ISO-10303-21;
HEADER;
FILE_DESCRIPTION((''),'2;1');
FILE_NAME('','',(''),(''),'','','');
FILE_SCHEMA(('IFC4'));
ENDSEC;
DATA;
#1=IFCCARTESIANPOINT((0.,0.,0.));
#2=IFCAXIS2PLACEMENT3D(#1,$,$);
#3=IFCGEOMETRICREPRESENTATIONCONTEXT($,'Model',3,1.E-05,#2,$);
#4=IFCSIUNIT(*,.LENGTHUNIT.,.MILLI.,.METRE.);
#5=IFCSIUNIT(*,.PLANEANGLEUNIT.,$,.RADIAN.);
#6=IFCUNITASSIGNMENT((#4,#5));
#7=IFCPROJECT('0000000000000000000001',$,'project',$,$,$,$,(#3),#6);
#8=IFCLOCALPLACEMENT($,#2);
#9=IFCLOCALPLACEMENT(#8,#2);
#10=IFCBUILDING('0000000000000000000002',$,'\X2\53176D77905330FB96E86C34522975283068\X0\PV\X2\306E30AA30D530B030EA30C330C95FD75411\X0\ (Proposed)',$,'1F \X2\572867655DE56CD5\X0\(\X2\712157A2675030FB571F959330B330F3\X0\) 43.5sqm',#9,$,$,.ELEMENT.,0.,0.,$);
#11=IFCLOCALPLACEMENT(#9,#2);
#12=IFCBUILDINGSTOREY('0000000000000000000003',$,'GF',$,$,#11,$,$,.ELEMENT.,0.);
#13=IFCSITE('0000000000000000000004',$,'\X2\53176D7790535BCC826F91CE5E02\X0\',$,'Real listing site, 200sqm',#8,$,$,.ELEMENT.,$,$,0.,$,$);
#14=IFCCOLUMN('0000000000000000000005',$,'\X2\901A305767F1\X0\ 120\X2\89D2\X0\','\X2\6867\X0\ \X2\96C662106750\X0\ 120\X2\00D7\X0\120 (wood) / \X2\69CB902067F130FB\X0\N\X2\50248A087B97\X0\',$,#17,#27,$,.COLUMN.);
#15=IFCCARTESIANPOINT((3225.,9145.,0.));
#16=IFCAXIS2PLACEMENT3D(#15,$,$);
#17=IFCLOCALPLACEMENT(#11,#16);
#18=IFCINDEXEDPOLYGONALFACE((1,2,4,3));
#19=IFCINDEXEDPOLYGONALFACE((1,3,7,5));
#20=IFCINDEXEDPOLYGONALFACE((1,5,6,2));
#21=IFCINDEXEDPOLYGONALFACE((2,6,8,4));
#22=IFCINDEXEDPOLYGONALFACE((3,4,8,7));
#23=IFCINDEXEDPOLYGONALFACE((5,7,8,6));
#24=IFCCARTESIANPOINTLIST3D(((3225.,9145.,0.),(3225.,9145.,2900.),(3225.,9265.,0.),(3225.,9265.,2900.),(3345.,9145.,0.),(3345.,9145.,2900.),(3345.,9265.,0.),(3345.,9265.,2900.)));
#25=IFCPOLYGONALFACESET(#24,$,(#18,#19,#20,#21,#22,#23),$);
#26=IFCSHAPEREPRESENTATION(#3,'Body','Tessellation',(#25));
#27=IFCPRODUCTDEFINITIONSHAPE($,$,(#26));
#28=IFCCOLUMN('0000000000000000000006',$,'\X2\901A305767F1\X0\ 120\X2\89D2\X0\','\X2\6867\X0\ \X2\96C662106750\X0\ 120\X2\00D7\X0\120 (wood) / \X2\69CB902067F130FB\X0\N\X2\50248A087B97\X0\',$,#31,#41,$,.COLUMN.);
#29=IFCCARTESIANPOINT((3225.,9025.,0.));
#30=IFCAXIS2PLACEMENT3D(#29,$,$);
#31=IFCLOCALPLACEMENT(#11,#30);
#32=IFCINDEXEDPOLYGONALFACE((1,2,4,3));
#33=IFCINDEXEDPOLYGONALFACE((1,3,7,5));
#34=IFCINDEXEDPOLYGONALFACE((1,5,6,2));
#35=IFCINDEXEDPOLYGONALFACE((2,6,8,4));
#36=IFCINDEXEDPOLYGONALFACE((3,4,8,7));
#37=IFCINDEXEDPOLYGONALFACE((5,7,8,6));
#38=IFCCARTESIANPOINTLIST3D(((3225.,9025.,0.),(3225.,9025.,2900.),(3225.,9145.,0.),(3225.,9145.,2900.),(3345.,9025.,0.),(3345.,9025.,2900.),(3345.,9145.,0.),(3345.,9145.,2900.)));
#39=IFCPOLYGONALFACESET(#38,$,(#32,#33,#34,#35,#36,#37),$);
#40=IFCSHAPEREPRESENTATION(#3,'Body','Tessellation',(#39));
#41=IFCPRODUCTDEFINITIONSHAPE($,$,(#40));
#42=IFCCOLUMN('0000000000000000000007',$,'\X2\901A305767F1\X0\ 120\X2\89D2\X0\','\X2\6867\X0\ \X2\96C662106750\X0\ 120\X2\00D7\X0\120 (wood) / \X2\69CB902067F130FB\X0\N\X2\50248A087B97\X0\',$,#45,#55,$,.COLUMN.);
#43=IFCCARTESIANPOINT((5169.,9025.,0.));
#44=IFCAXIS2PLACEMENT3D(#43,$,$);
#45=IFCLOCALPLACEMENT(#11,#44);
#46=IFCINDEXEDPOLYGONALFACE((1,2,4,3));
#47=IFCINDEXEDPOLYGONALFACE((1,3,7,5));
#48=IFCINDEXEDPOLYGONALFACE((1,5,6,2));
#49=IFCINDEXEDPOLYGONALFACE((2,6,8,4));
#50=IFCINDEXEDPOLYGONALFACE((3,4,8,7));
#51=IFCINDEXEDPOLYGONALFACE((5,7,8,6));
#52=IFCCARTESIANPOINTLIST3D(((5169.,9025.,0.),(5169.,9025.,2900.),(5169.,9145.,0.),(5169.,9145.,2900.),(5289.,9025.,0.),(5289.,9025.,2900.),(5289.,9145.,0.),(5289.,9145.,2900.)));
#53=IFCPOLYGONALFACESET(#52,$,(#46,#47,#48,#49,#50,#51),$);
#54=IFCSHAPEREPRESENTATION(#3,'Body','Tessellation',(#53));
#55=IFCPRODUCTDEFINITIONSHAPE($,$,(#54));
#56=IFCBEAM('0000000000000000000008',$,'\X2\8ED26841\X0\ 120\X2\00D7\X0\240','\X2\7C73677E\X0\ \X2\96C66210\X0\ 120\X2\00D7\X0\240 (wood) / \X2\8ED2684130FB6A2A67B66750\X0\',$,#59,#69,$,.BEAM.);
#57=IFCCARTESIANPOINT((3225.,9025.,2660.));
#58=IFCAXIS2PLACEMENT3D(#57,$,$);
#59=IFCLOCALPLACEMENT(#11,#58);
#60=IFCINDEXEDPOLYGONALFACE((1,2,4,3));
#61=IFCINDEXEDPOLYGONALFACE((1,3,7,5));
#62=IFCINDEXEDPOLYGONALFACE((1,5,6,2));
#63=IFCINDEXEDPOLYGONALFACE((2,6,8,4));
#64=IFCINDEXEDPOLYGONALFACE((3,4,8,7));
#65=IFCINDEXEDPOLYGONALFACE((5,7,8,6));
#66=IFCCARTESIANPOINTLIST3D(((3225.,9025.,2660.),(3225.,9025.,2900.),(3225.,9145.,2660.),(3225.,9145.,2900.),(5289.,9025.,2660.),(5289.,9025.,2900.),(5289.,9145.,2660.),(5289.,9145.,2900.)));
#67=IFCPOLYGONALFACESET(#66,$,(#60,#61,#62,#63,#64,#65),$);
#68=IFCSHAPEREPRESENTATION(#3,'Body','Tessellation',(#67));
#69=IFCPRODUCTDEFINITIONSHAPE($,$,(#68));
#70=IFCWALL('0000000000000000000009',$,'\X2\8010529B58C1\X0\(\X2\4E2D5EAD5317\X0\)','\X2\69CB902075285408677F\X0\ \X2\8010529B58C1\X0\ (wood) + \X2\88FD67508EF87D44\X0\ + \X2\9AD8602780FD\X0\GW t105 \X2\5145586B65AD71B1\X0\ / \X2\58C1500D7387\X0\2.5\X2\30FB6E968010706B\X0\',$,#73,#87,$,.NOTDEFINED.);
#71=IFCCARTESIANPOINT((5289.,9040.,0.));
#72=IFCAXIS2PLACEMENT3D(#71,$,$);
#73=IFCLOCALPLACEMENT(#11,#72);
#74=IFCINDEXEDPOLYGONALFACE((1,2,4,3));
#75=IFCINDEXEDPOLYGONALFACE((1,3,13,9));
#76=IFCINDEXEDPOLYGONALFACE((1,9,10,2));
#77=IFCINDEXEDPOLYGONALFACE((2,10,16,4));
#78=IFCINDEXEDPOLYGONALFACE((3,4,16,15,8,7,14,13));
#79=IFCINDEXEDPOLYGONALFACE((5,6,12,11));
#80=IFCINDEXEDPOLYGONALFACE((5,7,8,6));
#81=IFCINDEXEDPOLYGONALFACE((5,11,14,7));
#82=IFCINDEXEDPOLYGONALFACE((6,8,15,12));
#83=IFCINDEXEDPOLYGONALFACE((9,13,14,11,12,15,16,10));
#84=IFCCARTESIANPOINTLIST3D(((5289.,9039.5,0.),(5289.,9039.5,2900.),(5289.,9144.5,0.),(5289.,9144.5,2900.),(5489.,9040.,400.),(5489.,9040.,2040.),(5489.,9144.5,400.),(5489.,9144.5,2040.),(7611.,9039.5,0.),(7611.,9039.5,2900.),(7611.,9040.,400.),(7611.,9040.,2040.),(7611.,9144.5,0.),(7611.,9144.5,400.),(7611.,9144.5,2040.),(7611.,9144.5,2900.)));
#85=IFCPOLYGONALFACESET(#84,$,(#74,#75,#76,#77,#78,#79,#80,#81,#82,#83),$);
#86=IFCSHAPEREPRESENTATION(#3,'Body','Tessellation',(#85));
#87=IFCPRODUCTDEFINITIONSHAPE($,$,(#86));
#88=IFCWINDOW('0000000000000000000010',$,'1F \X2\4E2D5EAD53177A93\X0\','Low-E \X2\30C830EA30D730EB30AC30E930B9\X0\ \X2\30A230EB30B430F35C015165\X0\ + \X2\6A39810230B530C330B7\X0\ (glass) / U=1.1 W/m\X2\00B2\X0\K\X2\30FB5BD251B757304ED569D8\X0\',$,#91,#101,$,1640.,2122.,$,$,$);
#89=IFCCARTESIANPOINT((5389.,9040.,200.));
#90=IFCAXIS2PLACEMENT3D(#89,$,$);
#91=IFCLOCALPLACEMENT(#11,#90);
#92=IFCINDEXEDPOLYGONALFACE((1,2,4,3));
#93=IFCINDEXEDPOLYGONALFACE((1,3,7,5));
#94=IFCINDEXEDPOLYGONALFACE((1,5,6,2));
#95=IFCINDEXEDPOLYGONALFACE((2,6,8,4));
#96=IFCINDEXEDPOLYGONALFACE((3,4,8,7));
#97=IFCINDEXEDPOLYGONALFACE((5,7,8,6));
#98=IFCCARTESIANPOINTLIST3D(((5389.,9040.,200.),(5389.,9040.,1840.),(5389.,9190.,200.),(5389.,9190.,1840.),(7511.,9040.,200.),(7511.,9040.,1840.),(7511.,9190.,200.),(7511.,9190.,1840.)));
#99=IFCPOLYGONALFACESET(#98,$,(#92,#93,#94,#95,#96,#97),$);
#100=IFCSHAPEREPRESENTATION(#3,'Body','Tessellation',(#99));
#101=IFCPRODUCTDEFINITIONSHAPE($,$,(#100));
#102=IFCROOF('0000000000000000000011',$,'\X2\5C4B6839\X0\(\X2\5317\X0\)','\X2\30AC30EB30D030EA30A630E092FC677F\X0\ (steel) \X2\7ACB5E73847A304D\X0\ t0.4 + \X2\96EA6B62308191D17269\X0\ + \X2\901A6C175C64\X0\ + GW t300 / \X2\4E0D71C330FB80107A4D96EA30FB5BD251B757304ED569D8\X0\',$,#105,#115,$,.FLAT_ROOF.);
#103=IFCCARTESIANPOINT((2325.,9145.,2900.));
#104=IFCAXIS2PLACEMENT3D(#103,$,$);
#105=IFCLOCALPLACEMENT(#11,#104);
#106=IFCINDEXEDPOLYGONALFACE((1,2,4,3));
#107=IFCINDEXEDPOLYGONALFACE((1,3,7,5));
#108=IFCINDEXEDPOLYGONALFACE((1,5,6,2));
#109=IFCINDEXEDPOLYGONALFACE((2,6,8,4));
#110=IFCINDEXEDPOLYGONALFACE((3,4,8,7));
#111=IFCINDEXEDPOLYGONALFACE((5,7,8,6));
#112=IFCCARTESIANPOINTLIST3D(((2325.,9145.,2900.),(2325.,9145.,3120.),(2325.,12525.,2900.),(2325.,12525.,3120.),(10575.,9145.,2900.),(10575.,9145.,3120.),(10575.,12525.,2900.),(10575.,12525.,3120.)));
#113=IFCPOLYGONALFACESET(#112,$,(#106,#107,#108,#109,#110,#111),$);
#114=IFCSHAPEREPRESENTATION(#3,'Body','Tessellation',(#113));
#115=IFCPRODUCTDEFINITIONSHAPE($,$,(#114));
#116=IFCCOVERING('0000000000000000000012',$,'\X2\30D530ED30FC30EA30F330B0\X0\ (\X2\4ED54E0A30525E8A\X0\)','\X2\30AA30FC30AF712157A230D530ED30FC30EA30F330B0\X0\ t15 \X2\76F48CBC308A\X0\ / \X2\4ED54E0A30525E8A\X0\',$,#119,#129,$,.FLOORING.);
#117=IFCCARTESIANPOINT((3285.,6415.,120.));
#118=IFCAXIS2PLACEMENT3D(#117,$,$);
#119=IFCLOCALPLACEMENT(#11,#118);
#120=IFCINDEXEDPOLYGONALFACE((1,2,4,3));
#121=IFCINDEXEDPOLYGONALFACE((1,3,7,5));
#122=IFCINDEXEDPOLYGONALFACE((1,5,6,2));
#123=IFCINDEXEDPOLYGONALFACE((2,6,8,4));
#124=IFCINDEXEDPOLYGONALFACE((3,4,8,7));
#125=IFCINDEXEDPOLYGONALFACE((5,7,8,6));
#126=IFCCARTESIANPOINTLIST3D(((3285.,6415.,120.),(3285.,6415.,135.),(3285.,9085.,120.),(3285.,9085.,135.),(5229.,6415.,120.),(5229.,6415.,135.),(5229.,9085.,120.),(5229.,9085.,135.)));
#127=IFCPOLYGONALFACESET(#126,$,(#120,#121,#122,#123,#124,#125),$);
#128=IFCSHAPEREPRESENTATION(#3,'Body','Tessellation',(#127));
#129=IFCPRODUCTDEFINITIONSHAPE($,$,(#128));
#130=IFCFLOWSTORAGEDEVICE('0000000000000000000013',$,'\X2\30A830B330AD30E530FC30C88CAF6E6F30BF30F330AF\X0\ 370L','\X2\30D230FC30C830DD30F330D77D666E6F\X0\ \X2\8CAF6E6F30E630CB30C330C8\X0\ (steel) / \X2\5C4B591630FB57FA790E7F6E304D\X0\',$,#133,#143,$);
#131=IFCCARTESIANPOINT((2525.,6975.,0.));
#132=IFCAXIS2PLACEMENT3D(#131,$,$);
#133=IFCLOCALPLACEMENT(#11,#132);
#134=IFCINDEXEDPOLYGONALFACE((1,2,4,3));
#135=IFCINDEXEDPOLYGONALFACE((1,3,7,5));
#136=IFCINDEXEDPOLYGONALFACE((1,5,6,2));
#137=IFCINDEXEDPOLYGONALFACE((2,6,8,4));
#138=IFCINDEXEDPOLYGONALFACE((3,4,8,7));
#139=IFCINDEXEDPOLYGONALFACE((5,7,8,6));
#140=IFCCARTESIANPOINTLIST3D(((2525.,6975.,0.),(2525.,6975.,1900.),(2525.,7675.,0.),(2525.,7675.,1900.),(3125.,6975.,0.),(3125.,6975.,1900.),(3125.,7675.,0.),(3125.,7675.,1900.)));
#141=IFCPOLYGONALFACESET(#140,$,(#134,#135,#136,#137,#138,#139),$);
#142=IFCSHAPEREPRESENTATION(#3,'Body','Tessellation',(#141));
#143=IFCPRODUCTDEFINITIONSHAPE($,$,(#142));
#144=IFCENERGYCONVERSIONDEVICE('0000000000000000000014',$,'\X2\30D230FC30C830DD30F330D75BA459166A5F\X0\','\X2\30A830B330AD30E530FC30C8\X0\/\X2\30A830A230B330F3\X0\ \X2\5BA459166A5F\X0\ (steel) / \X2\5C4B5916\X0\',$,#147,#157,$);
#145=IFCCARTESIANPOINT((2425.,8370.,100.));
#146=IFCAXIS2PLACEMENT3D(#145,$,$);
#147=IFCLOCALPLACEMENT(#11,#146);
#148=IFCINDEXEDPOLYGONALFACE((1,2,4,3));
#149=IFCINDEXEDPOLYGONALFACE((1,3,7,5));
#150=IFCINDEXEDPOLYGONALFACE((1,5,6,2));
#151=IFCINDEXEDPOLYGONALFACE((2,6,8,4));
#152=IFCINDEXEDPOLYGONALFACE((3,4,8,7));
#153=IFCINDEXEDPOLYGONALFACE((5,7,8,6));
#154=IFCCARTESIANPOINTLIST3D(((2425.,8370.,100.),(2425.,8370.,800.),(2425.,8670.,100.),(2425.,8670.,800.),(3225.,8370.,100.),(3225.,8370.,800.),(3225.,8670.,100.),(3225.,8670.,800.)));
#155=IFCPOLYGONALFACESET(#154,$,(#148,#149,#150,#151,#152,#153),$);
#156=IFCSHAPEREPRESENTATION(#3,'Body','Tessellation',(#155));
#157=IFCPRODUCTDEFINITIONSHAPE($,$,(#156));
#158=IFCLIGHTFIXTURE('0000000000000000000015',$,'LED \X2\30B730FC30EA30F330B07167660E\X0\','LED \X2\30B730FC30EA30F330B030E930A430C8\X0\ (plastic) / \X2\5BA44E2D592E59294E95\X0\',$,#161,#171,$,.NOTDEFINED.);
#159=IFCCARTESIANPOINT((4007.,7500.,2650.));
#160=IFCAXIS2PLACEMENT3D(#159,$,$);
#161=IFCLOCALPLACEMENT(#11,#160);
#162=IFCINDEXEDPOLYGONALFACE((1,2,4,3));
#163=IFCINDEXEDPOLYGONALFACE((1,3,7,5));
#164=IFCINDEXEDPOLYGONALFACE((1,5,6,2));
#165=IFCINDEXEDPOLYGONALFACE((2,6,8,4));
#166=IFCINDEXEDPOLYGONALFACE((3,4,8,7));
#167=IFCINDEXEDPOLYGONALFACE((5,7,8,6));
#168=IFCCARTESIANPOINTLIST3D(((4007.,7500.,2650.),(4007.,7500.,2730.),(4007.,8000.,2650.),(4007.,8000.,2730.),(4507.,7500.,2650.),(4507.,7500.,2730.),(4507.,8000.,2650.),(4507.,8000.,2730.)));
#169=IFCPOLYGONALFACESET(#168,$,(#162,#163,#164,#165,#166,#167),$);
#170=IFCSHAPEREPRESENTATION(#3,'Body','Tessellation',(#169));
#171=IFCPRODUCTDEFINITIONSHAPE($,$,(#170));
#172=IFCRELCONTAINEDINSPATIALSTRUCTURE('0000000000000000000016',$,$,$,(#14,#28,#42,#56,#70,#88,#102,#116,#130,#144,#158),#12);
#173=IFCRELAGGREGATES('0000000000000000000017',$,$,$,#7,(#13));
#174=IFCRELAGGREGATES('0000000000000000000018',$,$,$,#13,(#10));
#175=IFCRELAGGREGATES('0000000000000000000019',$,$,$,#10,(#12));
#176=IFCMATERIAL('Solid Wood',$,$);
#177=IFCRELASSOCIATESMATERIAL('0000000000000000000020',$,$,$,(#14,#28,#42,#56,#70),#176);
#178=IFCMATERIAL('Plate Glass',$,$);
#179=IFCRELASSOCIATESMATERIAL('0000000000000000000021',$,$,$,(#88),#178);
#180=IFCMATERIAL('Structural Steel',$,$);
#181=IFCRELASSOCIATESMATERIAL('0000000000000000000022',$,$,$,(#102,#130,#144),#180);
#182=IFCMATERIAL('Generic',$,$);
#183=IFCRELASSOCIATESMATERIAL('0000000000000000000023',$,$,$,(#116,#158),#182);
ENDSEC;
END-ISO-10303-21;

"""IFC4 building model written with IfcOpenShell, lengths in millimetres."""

from ifc_helpers import new_model, si_unit, frame, frame_2d, origin, place, context, project, spatial, rectangle, extrude, material, element, fill, save


model = new_model("IFC4")

# Units and contexts
model_context = context("Model", 3, precision=1e-05, world=origin())
ifc_project = project(units=[si_unit("LENGTHUNIT", "METRE", prefix="MILLI"), si_unit("PLANEANGLEUNIT", "RADIAN")], contexts=[model_context])

# Site, building, storey
site_placement = place(None, origin())
site = spatial("IfcSite", under=ifc_project, at=site_placement, Name="北海道富良野市", ObjectType="Real listing site, 200sqm", CompositionType="ELEMENT", RefElevation=0.0)
building_placement = place(site_placement, origin())
building = spatial("IfcBuilding", under=site, at=building_placement, Name="北海道・雨水利用とPVのオフグリッド志向 (Proposed)", ObjectType="1F 在来工法(無垢材・土間コン) 43.5sqm", CompositionType="ELEMENT", ElevationOfRefHeight=0.0, ElevationOfTerrain=0.0)
storey_placement = place(building_placement, origin())
storey = spatial("IfcBuildingStorey", under=building, at=storey_placement, Name="GF", CompositionType="ELEMENT", Elevation=0.0)

# Columns
ifc_material_1 = material(Name="Solid Wood")
column_1_placement = place(storey_placement, frame((3225.0, 9145.0, 0.0)))
element("IfcColumn", 1, at=column_1_placement, inside=storey, material=ifc_material_1, Name="通し柱 120角", Description="桧 集成材 120×120 (wood) / 構造柱・N値計算", PredefinedType="COLUMN", context=model_context, shape_type="SweptSolid", body=[
    extrude(rectangle(XDim=120.0, YDim=120.0, at=frame_2d((60.0, 60.0))), frame((3225.0, 9145.0, 0.0)), (0.0, 0.0, 1.0), 2900.0),
])
column_2_placement = place(storey_placement, frame((3225.0, 9025.0, 0.0)))
element("IfcColumn", 2, at=column_2_placement, inside=storey, material=ifc_material_1, Name="通し柱 120角", Description="桧 集成材 120×120 (wood) / 構造柱・N値計算", PredefinedType="COLUMN", context=model_context, shape_type="SweptSolid", body=[
    extrude(rectangle(XDim=120.0, YDim=120.0, at=frame_2d((60.0, 60.0))), frame((3225.0, 9025.0, 0.0)), (0.0, 0.0, 1.0), 2900.0),
])
column_3_placement = place(storey_placement, frame((5169.0, 9025.0, 0.0)))
element("IfcColumn", 3, at=column_3_placement, inside=storey, material=ifc_material_1, Name="通し柱 120角", Description="桧 集成材 120×120 (wood) / 構造柱・N値計算", PredefinedType="COLUMN", context=model_context, shape_type="SweptSolid", body=[
    extrude(rectangle(XDim=120.0, YDim=120.0, at=frame_2d((60.0, 60.0))), frame((5169.0, 9025.0, 0.0)), (0.0, 0.0, 1.0), 2900.0),
])

# Beam
beam_1_placement = place(storey_placement, frame((3225.0, 9025.0, 2660.0)))
element("IfcBeam", 4, at=beam_1_placement, inside=storey, material=ifc_material_1, Name="軒桁 120×240", Description="米松 集成 120×240 (wood) / 軒桁・横架材", PredefinedType="BEAM", context=model_context, shape_type="SweptSolid", body=[
    extrude(rectangle(XDim=2064.0, YDim=120.0, at=frame_2d((1032.0, 60.0))), frame((3225.0, 9025.0, 2660.0)), (0.0, 0.0, 1.0), 240.0),
])

# Wall, opening, window
wall_placement = place(storey_placement, frame((5289.0, 9040.0, 0.0)))
wall = element("IfcWall", 5, at=wall_placement, inside=storey, material=ifc_material_1, Name="耐力壁(中庭北)", Description="構造用合板 耐力壁 (wood) + 製材軸組 + 高性能GW t105 充填断熱 / 壁倍率2.5・準耐火", PredefinedType="NOTDEFINED", context=model_context, shape_type="SweptSolid", body=[
    extrude(rectangle(XDim=2322.0, YDim=105.0, at=frame_2d((1161.0, 52.0))), frame((5289.0, 9040.0, 0.0)), (0.0, 0.0, 1.0), 2900.0),
])
opening_placement = place(storey_placement, frame((5389.0, 9040.0, 200.0)))
opening = element("IfcOpeningElement", 6, at=opening_placement, cuts=wall, PredefinedType="NOTDEFINED", context=model_context, shape_type="SweptSolid", body=[
    extrude(rectangle(XDim=2122.0, YDim=150.0, at=frame_2d((1061.0, 75.0))), frame((5389.0, 9040.0, 200.0)), (0.0, 0.0, 1.0), 1640.0),
])
ifc_material_2 = material(Name="Plate Glass")
window_placement = place(storey_placement, frame((5389.0, 9040.0, 200.0)))
window = element("IfcWindow", 7, at=window_placement, inside=storey, material=ifc_material_2, Name="1F 中庭北窓", Description="Low-E トリプルガラス アルゴン封入 + 樹脂サッシ (glass) / U=1.1 W/m²K・寒冷地仕様", OverallHeight=1640.0, OverallWidth=2122.0, context=model_context, shape_type="SweptSolid", body=[
    extrude(rectangle(XDim=2122.0, YDim=150.0, at=frame_2d((1061.0, 75.0))), frame((5389.0, 9040.0, 200.0)), (0.0, 0.0, 1.0), 1640.0),
])
fill(opening, window)

# Roof
ifc_material_3 = material(Name="Structural Steel")
roof_placement = place(storey_placement, frame((2325.0, 9145.0, 2900.0)))
element("IfcRoof", 8, at=roof_placement, inside=storey, material=ifc_material_3, Name="屋根(北)", Description="ガルバリウム鋼板 (steel) 立平葺き t0.4 + 雪止め金物 + 通気層 + GW t300 / 不燃・耐積雪・寒冷地仕様", PredefinedType="FLAT_ROOF", context=model_context, shape_type="SweptSolid", body=[
    extrude(rectangle(XDim=8250.0, YDim=3380.0, at=frame_2d((4125.0, 1690.0))), frame((2325.0, 9145.0, 2900.0)), (0.0, 0.0, 1.0), 220.0),
])

# Covering
ifc_material_4 = material(Name="Generic")
covering_placement = place(storey_placement, frame((3285.0, 6415.0, 120.0)))
element("IfcCovering", 9, at=covering_placement, inside=storey, material=ifc_material_4, Name="フローリング (仕上げ床)", Description="オーク無垢フローリング t15 直貼り / 仕上げ床", PredefinedType="FLOORING", context=model_context, shape_type="SweptSolid", body=[
    extrude(rectangle(XDim=1944.0, YDim=2670.0, at=frame_2d((972.0, 1335.0))), frame((3285.0, 6415.0, 120.0)), (0.0, 0.0, 1.0), 15.0),
])

# Flow storage device
flow_storage_device_placement = place(storey_placement, frame((2525.0, 6975.0, 0.0)))
element("IfcFlowStorageDevice", 10, at=flow_storage_device_placement, inside=storey, material=ifc_material_3, Name="エコキュート貯湯タンク 370L", Description="ヒートポンプ給湯 貯湯ユニット (steel) / 屋外・基礎置き", context=model_context, shape_type="SweptSolid", body=[
    extrude(rectangle(XDim=600.0, YDim=700.0, at=frame_2d((300.0, 350.0))), frame((2525.0, 6975.0, 0.0)), (0.0, 0.0, 1.0), 1900.0),
])

# Energy conversion device
energy_conversion_device_placement = place(storey_placement, frame((2425.0, 8370.0, 100.0)))
element("IfcEnergyConversionDevice", 11, at=energy_conversion_device_placement, inside=storey, material=ifc_material_3, Name="ヒートポンプ室外機", Description="エコキュート/エアコン 室外機 (steel) / 屋外", context=model_context, shape_type="SweptSolid", body=[
    extrude(rectangle(XDim=800.0, YDim=300.0, at=frame_2d((400.0, 150.0))), frame((2425.0, 8370.0, 100.0)), (0.0, 0.0, 1.0), 700.0),
])

# Light fixture
light_fixture_placement = place(storey_placement, frame((4007.0, 7500.0, 2650.0)))
element("IfcLightFixture", 12, at=light_fixture_placement, inside=storey, material=ifc_material_4, Name="LED シーリング照明", Description="LED シーリングライト (plastic) / 室中央天井", PredefinedType="NOTDEFINED", context=model_context, shape_type="SweptSolid", body=[
    extrude(rectangle(XDim=500.0, YDim=500.0, at=frame_2d((250.0, 250.0))), frame((4007.0, 7500.0, 2650.0)), (0.0, 0.0, 1.0), 80.0),
])

save(model, "model.ifc")
